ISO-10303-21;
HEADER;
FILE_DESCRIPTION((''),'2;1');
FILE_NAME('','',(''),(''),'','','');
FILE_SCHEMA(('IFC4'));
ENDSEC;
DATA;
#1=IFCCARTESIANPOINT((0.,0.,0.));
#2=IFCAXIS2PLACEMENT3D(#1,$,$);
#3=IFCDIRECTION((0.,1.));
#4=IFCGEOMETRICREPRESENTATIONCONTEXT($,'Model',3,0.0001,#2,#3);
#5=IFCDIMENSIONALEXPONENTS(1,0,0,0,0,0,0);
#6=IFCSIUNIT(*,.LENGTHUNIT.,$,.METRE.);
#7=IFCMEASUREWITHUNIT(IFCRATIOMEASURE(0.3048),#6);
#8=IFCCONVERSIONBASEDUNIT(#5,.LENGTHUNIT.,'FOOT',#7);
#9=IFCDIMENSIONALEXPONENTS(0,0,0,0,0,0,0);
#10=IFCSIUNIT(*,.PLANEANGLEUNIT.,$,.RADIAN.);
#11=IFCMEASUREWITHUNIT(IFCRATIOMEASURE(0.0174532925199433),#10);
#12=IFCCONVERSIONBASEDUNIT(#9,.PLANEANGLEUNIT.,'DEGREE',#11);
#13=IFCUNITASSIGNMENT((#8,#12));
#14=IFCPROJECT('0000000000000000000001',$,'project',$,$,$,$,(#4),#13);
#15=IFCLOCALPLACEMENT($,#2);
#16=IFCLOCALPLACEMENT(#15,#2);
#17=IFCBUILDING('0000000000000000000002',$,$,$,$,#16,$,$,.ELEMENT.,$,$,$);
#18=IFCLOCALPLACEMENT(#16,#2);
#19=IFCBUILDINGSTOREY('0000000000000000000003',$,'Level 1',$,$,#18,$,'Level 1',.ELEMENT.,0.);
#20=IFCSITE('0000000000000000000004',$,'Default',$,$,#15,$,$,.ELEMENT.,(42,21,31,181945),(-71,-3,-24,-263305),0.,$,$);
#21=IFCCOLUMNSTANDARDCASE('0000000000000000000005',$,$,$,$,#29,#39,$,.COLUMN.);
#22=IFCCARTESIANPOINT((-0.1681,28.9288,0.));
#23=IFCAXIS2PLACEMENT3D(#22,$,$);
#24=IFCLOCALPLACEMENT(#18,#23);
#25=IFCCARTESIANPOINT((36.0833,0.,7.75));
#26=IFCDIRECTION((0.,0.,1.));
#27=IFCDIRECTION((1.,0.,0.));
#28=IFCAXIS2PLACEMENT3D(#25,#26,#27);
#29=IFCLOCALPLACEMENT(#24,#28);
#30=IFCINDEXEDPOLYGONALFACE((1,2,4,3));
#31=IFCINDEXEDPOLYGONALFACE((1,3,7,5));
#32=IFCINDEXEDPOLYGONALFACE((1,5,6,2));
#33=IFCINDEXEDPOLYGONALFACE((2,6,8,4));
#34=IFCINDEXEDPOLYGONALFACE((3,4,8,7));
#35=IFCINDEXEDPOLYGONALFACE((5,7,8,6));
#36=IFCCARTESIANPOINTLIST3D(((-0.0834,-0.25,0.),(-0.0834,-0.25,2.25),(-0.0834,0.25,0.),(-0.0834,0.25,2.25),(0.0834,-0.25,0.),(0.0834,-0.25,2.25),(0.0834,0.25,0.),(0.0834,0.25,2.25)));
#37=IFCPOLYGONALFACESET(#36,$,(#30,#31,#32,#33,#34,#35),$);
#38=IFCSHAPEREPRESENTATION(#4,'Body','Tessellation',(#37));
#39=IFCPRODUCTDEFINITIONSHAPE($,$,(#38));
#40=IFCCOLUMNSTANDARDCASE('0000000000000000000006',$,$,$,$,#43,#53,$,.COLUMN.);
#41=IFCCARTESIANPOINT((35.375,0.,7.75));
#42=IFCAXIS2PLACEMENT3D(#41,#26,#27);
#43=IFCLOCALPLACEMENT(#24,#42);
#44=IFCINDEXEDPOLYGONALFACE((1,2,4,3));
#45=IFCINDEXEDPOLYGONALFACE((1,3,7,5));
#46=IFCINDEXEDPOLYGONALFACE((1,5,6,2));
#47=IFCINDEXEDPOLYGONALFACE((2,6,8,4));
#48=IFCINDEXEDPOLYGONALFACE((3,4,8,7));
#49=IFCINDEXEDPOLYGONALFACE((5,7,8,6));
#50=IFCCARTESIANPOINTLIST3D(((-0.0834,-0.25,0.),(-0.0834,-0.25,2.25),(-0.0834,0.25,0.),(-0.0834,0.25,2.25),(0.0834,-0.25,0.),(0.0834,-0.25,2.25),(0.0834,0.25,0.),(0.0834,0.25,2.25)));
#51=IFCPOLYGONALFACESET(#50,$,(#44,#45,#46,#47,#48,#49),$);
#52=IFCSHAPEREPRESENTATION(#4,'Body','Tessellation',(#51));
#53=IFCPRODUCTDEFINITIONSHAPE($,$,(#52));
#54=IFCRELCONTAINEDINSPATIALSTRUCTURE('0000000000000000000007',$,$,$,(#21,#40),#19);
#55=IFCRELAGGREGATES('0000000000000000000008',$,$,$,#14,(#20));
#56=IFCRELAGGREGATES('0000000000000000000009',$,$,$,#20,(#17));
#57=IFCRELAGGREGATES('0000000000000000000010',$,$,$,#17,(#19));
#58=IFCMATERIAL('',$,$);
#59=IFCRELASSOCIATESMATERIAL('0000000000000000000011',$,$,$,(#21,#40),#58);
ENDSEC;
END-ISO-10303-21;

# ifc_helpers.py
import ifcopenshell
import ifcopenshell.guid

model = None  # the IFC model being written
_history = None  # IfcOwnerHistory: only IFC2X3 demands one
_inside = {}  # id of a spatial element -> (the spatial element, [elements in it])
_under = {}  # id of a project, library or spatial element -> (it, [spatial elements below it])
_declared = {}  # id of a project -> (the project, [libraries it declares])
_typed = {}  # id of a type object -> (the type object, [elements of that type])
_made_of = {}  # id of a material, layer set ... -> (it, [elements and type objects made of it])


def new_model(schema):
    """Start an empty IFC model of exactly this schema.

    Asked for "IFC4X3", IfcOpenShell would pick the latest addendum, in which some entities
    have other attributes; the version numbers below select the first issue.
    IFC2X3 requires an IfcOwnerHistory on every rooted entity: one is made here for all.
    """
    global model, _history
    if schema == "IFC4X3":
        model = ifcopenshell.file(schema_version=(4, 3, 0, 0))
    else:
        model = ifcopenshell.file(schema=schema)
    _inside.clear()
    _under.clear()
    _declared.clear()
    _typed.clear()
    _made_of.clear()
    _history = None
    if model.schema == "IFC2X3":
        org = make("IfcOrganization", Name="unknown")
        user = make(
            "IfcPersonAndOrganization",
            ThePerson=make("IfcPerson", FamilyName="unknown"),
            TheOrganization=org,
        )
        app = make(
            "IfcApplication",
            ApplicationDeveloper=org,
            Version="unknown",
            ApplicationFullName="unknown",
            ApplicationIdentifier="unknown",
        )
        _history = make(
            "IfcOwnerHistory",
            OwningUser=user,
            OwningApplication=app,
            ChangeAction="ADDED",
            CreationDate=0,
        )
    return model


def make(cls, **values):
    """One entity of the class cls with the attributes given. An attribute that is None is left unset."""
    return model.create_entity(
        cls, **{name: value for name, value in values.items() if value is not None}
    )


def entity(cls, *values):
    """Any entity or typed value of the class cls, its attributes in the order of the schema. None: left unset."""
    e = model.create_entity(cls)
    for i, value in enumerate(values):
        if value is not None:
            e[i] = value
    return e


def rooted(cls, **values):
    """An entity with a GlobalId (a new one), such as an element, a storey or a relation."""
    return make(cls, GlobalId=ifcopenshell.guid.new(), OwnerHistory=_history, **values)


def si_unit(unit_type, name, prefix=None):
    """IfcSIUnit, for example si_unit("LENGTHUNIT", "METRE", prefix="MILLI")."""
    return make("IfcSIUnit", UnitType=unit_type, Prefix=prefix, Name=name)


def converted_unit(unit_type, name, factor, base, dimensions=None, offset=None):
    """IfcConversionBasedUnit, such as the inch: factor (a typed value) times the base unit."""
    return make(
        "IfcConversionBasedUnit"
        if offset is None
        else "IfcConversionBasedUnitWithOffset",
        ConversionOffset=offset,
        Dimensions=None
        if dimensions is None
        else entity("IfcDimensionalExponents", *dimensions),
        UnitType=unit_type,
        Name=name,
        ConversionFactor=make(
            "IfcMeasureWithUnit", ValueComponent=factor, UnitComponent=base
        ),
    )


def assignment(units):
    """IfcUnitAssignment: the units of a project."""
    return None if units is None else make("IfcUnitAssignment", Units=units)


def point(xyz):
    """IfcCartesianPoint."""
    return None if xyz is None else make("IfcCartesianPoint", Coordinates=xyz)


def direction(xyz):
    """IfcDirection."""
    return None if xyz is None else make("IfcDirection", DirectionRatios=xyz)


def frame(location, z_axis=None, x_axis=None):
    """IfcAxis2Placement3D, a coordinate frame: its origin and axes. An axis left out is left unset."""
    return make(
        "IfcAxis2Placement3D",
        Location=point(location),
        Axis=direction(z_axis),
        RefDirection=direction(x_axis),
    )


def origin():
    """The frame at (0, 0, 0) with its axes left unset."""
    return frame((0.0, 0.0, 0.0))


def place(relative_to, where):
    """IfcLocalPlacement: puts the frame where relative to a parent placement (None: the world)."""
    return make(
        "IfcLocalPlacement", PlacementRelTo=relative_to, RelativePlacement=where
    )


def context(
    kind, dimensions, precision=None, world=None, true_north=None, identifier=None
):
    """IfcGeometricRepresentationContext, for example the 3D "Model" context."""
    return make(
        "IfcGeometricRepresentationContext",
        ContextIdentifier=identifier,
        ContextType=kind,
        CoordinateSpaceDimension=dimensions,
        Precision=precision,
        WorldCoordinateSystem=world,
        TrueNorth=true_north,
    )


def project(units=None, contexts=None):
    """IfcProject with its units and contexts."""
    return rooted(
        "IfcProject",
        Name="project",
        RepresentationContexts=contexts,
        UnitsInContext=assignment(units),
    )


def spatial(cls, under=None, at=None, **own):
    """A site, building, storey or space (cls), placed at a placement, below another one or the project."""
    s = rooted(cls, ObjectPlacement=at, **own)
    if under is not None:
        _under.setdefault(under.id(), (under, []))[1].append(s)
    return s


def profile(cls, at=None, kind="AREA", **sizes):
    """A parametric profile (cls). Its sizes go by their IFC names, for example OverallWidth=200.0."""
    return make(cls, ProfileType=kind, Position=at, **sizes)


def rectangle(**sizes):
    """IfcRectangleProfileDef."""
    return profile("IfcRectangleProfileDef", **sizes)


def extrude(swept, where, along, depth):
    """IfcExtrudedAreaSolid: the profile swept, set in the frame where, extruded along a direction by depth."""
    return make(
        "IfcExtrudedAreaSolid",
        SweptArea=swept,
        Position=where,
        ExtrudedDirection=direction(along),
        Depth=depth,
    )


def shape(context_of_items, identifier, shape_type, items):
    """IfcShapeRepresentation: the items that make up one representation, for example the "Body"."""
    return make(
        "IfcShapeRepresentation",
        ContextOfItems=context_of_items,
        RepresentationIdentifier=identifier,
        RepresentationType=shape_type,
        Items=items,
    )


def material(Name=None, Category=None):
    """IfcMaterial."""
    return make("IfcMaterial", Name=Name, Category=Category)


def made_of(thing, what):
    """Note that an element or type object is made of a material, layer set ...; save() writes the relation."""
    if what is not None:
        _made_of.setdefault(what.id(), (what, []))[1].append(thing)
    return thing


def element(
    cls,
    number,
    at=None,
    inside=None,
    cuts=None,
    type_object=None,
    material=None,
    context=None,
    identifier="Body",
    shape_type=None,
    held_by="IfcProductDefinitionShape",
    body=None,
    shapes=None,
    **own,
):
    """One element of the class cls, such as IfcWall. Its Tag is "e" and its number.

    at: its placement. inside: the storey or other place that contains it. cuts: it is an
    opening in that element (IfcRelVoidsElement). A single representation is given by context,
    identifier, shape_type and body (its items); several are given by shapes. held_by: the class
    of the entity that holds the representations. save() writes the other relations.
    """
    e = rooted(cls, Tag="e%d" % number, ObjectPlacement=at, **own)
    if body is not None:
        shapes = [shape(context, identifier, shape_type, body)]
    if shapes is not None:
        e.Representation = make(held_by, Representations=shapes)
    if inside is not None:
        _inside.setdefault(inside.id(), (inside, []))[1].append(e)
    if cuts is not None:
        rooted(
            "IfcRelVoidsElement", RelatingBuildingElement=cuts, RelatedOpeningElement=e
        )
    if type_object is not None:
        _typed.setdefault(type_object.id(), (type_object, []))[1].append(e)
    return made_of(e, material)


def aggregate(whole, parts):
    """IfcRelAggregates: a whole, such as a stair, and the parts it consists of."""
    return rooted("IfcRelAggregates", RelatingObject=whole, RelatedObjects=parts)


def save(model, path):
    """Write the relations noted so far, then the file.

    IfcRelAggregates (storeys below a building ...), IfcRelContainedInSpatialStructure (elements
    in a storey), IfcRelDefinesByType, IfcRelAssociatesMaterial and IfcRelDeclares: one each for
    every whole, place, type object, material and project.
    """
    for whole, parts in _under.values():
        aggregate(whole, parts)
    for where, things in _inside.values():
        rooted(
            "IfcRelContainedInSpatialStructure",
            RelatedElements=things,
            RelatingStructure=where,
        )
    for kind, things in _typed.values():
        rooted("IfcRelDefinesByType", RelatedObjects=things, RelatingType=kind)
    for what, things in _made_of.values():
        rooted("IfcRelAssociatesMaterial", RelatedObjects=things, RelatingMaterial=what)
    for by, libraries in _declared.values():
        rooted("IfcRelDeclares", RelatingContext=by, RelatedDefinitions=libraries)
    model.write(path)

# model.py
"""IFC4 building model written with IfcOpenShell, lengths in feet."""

from ifc_helpers import new_model, entity, si_unit, converted_unit, direction, frame, origin, place, context, project, spatial, rectangle, extrude, material, element, save


model = new_model("IFC4")

# Units and contexts
model_context = context("Model", 3, precision=0.0001, world=origin(), true_north=direction((0.0, 1.0)))
ifc_project = project(units=[converted_unit("LENGTHUNIT", "FOOT", entity("IfcRatioMeasure", 0.3048), si_unit("LENGTHUNIT", "METRE"), dimensions=[1, 0, 0, 0, 0, 0, 0]), converted_unit("PLANEANGLEUNIT", "DEGREE", entity("IfcRatioMeasure", 0.0174532925199433), si_unit("PLANEANGLEUNIT", "RADIAN"), dimensions=[0, 0, 0, 0, 0, 0, 0])], contexts=[model_context])

# Site, building, storey
site_placement = place(None, origin())
site = spatial("IfcSite", under=ifc_project, at=site_placement, Name="Default", CompositionType="ELEMENT", RefLatitude=(42, 21, 31, 181945), RefLongitude=(-71, -3, -24, -263305), RefElevation=0.0)
building_placement = place(site_placement, origin())
building = spatial("IfcBuilding", under=site, at=building_placement, CompositionType="ELEMENT")
storey_placement = place(building_placement, origin())
storey = spatial("IfcBuildingStorey", under=building, at=storey_placement, Name="Level 1", LongName="Level 1", CompositionType="ELEMENT", Elevation=0.0)

# Columns
ifc_material = material(Name="")
placement = place(storey_placement, frame((-0.1681, 28.9288, 0.0)))
for number, where, z_axis, x_axis in (
    (1, (36.0833, 0.0, 7.75), (0.0, 0.0, 1.0), (1.0, 0.0, 0.0)),
    (2, (35.375, 0.0, 7.75), (0.0, 0.0, 1.0), (1.0, 0.0, 0.0)),
):
    element("IfcColumnStandardCase", number, at=place(placement, frame(where, z_axis=z_axis, x_axis=x_axis)), inside=storey, material=ifc_material, PredefinedType="COLUMN", context=model_context, shape_type="SweptSolid", body=[
        extrude(rectangle(XDim=0.1667, YDim=0.5), origin(), (0.0, 0.0, 1.0), 2.25),
    ])

save(model, "model.ifc")
